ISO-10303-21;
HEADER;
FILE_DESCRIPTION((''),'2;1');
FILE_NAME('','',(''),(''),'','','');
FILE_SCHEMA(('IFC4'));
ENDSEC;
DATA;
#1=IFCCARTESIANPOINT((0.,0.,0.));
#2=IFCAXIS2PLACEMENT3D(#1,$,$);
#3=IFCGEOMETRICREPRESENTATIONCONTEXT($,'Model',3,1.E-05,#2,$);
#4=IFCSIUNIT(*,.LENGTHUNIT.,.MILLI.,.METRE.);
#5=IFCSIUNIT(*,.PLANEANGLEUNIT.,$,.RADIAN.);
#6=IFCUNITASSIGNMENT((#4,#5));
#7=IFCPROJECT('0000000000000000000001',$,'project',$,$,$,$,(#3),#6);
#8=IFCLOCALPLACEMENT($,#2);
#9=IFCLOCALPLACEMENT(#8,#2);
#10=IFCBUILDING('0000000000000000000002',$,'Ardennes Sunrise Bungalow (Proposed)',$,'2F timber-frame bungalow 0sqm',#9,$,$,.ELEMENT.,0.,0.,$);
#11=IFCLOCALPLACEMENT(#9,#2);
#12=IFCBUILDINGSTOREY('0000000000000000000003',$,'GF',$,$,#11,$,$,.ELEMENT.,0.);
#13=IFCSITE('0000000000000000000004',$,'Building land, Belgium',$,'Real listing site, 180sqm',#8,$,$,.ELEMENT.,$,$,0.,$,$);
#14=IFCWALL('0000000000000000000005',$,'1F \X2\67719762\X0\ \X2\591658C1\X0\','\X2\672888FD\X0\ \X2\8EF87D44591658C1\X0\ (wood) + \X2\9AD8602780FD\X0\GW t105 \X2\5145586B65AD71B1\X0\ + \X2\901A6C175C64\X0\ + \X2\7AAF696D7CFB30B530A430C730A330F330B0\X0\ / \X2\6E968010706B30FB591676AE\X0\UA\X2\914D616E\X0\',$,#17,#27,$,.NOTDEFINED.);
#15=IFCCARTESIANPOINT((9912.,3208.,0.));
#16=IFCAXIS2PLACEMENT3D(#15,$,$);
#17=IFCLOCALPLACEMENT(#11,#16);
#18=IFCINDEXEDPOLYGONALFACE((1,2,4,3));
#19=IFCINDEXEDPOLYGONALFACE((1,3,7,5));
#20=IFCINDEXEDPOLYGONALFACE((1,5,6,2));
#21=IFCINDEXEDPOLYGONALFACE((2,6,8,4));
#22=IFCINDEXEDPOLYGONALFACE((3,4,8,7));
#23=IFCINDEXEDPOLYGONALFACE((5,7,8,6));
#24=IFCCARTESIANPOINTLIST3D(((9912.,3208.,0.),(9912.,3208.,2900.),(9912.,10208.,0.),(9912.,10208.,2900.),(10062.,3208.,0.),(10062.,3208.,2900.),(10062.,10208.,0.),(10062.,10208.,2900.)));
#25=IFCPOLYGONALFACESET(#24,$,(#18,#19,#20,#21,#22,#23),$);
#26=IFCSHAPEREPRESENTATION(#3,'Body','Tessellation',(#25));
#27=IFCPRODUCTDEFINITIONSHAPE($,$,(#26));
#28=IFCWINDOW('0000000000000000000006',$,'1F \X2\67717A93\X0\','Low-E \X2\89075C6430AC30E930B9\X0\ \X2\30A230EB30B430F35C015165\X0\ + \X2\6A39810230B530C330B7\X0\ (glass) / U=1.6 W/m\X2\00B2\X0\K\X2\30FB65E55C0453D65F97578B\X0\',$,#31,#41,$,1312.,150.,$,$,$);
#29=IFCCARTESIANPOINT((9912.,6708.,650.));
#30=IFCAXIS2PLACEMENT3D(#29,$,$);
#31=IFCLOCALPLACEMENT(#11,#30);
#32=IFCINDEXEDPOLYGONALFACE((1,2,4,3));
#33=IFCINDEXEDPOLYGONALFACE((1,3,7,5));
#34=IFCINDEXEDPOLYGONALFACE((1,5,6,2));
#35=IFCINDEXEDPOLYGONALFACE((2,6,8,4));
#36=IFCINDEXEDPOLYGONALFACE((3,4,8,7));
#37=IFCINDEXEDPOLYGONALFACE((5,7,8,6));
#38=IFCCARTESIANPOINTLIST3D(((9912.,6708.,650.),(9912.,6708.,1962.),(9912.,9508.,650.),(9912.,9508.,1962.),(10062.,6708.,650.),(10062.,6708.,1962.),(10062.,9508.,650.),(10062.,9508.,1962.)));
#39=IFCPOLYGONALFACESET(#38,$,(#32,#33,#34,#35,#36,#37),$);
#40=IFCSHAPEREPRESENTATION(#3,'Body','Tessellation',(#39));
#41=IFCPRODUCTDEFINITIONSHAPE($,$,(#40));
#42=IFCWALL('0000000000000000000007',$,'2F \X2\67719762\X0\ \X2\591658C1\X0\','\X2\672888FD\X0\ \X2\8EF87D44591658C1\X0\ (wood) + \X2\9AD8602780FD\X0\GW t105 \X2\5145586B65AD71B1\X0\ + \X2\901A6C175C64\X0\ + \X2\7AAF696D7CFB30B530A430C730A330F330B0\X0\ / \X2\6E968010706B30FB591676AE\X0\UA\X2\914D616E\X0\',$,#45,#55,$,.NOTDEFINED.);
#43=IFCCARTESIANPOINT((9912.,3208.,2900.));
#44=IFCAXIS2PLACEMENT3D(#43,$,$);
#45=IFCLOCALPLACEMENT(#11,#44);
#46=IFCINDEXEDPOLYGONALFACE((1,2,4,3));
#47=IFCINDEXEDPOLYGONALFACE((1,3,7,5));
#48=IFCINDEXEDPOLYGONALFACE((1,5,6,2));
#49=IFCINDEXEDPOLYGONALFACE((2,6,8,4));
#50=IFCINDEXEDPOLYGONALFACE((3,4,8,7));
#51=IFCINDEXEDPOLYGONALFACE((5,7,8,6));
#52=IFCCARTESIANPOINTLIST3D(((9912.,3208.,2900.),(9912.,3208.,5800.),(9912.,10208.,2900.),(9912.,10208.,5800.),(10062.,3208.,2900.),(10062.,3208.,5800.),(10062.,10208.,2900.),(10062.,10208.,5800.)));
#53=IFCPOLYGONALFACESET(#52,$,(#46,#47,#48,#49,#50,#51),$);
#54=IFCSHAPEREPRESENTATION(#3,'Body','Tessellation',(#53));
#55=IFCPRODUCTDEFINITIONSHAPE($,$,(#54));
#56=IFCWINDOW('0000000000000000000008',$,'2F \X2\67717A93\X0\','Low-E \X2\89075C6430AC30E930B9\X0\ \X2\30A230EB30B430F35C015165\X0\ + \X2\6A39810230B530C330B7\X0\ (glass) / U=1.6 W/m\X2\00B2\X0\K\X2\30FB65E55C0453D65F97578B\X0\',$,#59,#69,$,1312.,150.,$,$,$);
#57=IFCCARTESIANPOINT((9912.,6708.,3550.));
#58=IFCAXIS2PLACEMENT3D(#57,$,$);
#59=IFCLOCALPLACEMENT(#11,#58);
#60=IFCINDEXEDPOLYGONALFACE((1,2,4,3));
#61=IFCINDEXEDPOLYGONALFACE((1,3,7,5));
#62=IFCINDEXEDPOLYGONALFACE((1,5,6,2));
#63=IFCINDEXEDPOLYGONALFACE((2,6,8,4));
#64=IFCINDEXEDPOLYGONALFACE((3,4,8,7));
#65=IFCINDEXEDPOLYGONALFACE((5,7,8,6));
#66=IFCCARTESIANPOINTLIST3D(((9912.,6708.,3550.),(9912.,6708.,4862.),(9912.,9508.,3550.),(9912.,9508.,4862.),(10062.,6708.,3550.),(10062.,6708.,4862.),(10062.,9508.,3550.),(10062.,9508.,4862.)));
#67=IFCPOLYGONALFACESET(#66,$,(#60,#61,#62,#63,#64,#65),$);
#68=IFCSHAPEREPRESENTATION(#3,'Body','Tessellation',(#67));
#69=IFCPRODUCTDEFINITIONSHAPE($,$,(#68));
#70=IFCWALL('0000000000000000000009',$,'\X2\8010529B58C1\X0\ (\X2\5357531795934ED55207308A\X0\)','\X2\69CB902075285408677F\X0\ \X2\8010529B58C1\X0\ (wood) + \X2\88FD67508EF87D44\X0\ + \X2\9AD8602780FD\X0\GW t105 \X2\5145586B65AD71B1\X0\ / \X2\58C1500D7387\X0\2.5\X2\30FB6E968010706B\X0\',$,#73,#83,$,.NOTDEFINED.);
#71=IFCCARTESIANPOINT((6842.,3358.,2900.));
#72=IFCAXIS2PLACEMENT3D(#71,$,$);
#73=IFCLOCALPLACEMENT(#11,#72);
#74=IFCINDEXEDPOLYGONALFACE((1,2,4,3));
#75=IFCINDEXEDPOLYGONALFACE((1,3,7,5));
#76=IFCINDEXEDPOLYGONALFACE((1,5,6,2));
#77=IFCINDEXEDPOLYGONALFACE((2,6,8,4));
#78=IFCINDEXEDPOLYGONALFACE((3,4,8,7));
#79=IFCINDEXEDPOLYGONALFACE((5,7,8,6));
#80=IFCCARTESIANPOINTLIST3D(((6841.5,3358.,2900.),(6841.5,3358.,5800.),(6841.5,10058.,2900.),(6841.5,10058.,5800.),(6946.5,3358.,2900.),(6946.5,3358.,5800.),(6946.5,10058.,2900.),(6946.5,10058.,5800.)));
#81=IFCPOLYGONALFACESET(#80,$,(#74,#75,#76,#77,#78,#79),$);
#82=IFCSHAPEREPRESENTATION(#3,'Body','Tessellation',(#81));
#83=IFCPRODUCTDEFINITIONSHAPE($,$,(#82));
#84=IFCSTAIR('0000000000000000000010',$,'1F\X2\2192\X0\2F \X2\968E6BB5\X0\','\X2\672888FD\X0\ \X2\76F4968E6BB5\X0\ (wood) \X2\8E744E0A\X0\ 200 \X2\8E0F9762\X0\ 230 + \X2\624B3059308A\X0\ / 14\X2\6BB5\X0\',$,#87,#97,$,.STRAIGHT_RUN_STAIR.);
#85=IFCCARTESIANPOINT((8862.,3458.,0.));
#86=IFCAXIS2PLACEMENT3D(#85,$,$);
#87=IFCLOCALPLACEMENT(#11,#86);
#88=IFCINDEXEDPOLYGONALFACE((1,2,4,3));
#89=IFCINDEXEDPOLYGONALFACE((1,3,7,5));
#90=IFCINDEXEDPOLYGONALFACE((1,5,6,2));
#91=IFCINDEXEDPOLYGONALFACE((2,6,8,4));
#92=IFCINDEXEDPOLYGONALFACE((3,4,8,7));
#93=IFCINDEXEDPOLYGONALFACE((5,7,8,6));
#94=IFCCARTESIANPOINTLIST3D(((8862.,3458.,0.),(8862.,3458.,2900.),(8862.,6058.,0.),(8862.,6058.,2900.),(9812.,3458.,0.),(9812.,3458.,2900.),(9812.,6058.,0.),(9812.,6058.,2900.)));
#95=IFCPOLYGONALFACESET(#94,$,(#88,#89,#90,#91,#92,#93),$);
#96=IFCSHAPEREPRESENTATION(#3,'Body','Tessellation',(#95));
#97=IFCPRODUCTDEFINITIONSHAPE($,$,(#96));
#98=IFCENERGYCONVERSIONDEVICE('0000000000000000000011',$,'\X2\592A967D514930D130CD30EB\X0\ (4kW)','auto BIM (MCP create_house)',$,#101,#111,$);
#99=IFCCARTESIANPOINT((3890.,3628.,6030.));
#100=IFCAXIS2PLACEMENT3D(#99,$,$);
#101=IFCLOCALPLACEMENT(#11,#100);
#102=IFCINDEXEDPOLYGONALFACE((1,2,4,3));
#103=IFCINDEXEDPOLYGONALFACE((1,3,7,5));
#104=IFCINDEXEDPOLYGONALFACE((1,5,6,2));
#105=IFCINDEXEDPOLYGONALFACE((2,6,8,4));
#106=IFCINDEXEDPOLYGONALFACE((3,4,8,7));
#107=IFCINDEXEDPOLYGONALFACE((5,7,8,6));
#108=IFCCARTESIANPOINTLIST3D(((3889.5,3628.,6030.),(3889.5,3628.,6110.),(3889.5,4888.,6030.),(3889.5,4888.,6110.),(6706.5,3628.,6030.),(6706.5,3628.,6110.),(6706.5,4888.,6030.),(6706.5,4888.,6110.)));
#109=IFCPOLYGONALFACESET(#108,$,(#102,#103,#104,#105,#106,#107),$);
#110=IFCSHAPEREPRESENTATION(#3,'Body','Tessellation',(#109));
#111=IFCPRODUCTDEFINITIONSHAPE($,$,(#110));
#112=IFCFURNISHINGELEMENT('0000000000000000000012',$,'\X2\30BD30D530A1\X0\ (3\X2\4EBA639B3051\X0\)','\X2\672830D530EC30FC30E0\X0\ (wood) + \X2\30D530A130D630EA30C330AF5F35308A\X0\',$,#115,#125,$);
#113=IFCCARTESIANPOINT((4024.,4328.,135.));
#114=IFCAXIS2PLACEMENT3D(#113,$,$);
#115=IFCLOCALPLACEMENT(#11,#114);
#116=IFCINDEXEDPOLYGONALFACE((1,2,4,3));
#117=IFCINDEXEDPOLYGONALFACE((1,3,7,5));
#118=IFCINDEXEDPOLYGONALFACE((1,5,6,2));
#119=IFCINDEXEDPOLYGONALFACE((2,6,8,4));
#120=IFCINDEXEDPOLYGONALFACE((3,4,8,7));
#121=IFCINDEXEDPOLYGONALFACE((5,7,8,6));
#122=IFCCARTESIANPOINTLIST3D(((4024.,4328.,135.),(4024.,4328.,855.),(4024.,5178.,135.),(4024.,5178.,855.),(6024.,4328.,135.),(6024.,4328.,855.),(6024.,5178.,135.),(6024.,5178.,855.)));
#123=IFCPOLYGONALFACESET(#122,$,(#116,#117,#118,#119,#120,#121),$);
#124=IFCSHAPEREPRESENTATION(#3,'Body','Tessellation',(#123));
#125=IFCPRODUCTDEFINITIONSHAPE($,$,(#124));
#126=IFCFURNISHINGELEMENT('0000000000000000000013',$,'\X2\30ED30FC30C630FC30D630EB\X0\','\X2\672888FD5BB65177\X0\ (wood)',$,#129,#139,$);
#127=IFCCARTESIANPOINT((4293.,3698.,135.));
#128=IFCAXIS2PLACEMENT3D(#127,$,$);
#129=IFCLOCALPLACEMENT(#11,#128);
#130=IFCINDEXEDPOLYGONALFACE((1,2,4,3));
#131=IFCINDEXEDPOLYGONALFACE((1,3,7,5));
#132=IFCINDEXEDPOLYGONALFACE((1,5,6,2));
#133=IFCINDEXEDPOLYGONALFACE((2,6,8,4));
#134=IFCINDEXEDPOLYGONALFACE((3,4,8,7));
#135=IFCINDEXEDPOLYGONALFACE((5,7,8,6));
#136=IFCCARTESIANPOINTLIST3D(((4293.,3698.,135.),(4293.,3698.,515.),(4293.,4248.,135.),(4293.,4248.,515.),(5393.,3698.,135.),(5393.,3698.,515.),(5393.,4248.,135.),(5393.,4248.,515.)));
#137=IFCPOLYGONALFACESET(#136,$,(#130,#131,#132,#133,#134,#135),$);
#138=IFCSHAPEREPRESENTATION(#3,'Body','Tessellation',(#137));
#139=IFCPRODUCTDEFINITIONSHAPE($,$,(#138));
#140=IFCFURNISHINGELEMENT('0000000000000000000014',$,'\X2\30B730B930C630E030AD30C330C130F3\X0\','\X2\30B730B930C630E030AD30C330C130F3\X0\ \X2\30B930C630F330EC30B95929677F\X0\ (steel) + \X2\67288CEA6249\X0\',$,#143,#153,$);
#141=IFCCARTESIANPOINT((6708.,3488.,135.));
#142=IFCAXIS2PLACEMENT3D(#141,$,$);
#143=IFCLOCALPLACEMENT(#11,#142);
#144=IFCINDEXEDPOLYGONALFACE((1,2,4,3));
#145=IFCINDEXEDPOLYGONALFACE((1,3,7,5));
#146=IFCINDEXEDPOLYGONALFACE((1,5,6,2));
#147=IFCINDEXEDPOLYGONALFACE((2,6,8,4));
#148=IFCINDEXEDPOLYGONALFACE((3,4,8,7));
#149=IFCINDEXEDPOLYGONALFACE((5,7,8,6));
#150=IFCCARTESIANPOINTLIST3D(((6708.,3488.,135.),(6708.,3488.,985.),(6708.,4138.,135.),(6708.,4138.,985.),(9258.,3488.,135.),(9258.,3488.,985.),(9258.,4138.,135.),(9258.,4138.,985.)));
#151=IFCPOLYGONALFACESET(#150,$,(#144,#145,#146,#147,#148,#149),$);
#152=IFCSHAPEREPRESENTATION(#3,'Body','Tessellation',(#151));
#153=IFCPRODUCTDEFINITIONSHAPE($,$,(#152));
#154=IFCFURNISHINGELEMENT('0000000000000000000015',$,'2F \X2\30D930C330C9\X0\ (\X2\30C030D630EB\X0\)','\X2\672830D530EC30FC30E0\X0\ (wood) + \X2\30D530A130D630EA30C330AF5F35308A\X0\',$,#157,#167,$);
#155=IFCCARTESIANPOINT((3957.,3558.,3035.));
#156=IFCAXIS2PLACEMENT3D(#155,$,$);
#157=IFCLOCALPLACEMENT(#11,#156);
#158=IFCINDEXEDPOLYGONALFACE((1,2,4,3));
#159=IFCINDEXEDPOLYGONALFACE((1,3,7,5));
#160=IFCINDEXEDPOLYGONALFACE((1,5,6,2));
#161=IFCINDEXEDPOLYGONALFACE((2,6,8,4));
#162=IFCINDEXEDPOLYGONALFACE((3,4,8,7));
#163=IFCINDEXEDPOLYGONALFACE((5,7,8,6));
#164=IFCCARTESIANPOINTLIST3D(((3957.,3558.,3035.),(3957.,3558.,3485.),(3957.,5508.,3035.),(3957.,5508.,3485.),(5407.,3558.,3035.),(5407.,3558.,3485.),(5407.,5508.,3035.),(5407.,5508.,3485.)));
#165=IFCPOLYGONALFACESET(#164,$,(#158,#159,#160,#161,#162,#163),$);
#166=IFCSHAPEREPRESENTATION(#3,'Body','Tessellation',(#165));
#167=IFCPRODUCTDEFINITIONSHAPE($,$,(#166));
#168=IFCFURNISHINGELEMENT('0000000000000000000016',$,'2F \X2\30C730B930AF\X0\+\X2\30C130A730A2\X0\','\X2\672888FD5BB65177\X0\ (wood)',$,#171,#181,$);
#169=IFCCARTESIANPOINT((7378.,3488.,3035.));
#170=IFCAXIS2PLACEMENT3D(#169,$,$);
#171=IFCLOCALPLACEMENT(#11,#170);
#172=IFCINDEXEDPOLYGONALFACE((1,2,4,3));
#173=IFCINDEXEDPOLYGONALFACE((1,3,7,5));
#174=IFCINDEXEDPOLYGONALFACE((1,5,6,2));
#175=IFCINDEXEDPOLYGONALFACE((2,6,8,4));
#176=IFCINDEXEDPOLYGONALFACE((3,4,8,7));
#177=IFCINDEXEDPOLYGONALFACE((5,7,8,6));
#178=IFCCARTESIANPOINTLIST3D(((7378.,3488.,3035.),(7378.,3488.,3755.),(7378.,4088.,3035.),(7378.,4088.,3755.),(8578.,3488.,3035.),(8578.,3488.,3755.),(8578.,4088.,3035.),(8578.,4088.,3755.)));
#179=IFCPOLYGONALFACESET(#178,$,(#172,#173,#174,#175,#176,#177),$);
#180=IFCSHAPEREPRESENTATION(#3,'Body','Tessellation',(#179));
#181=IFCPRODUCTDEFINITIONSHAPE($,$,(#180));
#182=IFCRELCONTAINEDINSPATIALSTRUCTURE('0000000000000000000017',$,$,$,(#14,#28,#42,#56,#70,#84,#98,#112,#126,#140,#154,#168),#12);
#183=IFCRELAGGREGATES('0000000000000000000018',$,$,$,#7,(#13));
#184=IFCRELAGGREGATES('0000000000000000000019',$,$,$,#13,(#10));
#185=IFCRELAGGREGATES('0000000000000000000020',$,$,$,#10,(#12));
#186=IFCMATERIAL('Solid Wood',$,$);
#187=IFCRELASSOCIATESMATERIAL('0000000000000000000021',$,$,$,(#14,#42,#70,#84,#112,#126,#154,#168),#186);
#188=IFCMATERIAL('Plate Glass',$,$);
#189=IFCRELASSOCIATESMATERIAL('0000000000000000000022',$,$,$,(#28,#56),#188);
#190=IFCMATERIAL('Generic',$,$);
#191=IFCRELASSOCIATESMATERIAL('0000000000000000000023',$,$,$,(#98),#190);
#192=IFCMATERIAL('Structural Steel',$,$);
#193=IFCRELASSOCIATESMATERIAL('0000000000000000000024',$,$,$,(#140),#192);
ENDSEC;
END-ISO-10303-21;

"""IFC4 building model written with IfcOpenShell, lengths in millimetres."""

from ifc_helpers import new_model, si_unit, frame, frame_2d, origin, place, context, project, spatial, rectangle, extrude, material, element, fill, save


model = new_model("IFC4")

# Units and contexts
model_context = context("Model", 3, precision=1e-05, world=origin())
ifc_project = project(units=[si_unit("LENGTHUNIT", "METRE", prefix="MILLI"), si_unit("PLANEANGLEUNIT", "RADIAN")], contexts=[model_context])

# Site, building, storey
site_placement = place(None, origin())
site = spatial("IfcSite", under=ifc_project, at=site_placement, Name="Building land, Belgium", ObjectType="Real listing site, 180sqm", CompositionType="ELEMENT", RefElevation=0.0)
building_placement = place(site_placement, origin())
building = spatial("IfcBuilding", under=site, at=building_placement, Name="Ardennes Sunrise Bungalow (Proposed)", ObjectType="2F timber-frame bungalow 0sqm", CompositionType="ELEMENT", ElevationOfRefHeight=0.0, ElevationOfTerrain=0.0)
storey_placement = place(building_placement, origin())
storey = spatial("IfcBuildingStorey", under=building, at=storey_placement, Name="GF", CompositionType="ELEMENT", Elevation=0.0)

# Wall, opening, window
ifc_material_1 = material(Name="Solid Wood")
wall_1_placement = place(storey_placement, frame((9912.0, 3208.0, 0.0)))
wall_1 = element("IfcWall", 1, at=wall_1_placement, inside=storey, material=ifc_material_1, Name="1F 東面 外壁", Description="木製 軸組外壁 (wood) + 高性能GW t105 充填断熱 + 通気層 + 窯業系サイディング / 準耐火・外皮UA配慮", PredefinedType="NOTDEFINED", context=model_context, shape_type="SweptSolid", body=[
    extrude(rectangle(XDim=150.0, YDim=7000.0, at=frame_2d((75.0, 3500.0))), frame((9912.0, 3208.0, 0.0)), (0.0, 0.0, 1.0), 2900.0),
])
opening_1_placement = place(storey_placement, frame((9912.0, 6708.0, 650.0)))
opening_1 = element("IfcOpeningElement", 2, at=opening_1_placement, cuts=wall_1, PredefinedType="NOTDEFINED", context=model_context, shape_type="SweptSolid", body=[
    extrude(rectangle(XDim=150.0, YDim=2800.0, at=frame_2d((75.0, 1400.0))), frame((9912.0, 6708.0, 650.0)), (0.0, 0.0, 1.0), 1312.0),
])
ifc_material_2 = material(Name="Plate Glass")
window_1_placement = place(storey_placement, frame((9912.0, 6708.0, 650.0)))
window_1 = element("IfcWindow", 3, at=window_1_placement, inside=storey, material=ifc_material_2, Name="1F 東窓", Description="Low-E 複層ガラス アルゴン封入 + 樹脂サッシ (glass) / U=1.6 W/m²K・日射取得型", OverallHeight=1312.0, OverallWidth=150.0, context=model_context, shape_type="SweptSolid", body=[
    extrude(rectangle(XDim=150.0, YDim=2800.0, at=frame_2d((75.0, 1400.0))), frame((9912.0, 6708.0, 650.0)), (0.0, 0.0, 1.0), 1312.0),
])
fill(opening_1, window_1)

# Wall, opening, window
wall_2_placement = place(storey_placement, frame((9912.0, 3208.0, 2900.0)))
wall_2 = element("IfcWall", 4, at=wall_2_placement, inside=storey, material=ifc_material_1, Name="2F 東面 外壁", Description="木製 軸組外壁 (wood) + 高性能GW t105 充填断熱 + 通気層 + 窯業系サイディング / 準耐火・外皮UA配慮", PredefinedType="NOTDEFINED", context=model_context, shape_type="SweptSolid", body=[
    extrude(rectangle(XDim=150.0, YDim=7000.0, at=frame_2d((75.0, 3500.0))), frame((9912.0, 3208.0, 2900.0)), (0.0, 0.0, 1.0), 2900.0),
])
opening_2_placement = place(storey_placement, frame((9912.0, 6708.0, 3550.0)))
opening_2 = element("IfcOpeningElement", 5, at=opening_2_placement, cuts=wall_2, PredefinedType="NOTDEFINED", context=model_context, shape_type="SweptSolid", body=[
    extrude(rectangle(XDim=150.0, YDim=2800.0, at=frame_2d((75.0, 1400.0))), frame((9912.0, 6708.0, 3550.0)), (0.0, 0.0, 1.0), 1312.0),
])
window_2_placement = place(storey_placement, frame((9912.0, 6708.0, 3550.0)))
window_2 = element("IfcWindow", 6, at=window_2_placement, inside=storey, material=ifc_material_2, Name="2F 東窓", Description="Low-E 複層ガラス アルゴン封入 + 樹脂サッシ (glass) / U=1.6 W/m²K・日射取得型", OverallHeight=1312.0, OverallWidth=150.0, context=model_context, shape_type="SweptSolid", body=[
    extrude(rectangle(XDim=150.0, YDim=2800.0, at=frame_2d((75.0, 1400.0))), frame((9912.0, 6708.0, 3550.0)), (0.0, 0.0, 1.0), 1312.0),
])
fill(opening_2, window_2)

# Wall
wall_3_placement = place(storey_placement, frame((6842.0, 3358.0, 2900.0)))
element("IfcWall", 7, at=wall_3_placement, inside=storey, material=ifc_material_1, Name="耐力壁 (南北間仕切り)", Description="構造用合板 耐力壁 (wood) + 製材軸組 + 高性能GW t105 充填断熱 / 壁倍率2.5・準耐火", PredefinedType="NOTDEFINED", context=model_context, shape_type="SweptSolid", body=[
    extrude(rectangle(XDim=105.0, YDim=6700.0, at=frame_2d((52.0, 3350.0))), frame((6842.0, 3358.0, 2900.0)), (0.0, 0.0, 1.0), 2900.0),
])

# Stair
stair_placement = place(storey_placement, frame((8862.0, 3458.0, 0.0)))
element("IfcStair", 8, at=stair_placement, inside=storey, material=ifc_material_1, Name="1F→2F 階段", Description="木製 直階段 (wood) 蹴上 200 踏面 230 + 手すり / 14段", PredefinedType="STRAIGHT_RUN_STAIR", context=model_context, shape_type="SweptSolid", body=[
    extrude(rectangle(XDim=950.0, YDim=2600.0, at=frame_2d((475.0, 1300.0))), frame((8862.0, 3458.0, 0.0)), (0.0, 0.0, 1.0), 2900.0),
])

# Energy conversion device
ifc_material_3 = material(Name="Generic")
energy_conversion_device_placement = place(storey_placement, frame((3890.0, 3628.0, 6030.0)))
element("IfcEnergyConversionDevice", 9, at=energy_conversion_device_placement, inside=storey, material=ifc_material_3, Name="太陽光パネル (4kW)", Description="auto BIM (MCP create_house)", context=model_context, shape_type="SweptSolid", body=[
    extrude(rectangle(XDim=2817.0, YDim=1260.0, at=frame_2d((1408.0, 630.0))), frame((3890.0, 3628.0, 6030.0)), (0.0, 0.0, 1.0), 80.0),
])

# Furnishing elements
furnishing_1_placement = place(storey_placement, frame((4024.0, 4328.0, 135.0)))
element("IfcFurnishingElement", 10, at=furnishing_1_placement, inside=storey, material=ifc_material_1, Name="ソファ (3人掛け)", Description="木フレーム (wood) + ファブリック張り", context=model_context, shape_type="SweptSolid", body=[
    extrude(rectangle(XDim=2000.0, YDim=850.0, at=frame_2d((1000.0, 425.0))), frame((4024.0, 4328.0, 135.0)), (0.0, 0.0, 1.0), 720.0),
])
furnishing_2_placement = place(storey_placement, frame((4293.0, 3698.0, 135.0)))
element("IfcFurnishingElement", 11, at=furnishing_2_placement, inside=storey, material=ifc_material_1, Name="ローテーブル", Description="木製家具 (wood)", context=model_context, shape_type="SweptSolid", body=[
    extrude(rectangle(XDim=1100.0, YDim=550.0, at=frame_2d((550.0, 275.0))), frame((4293.0, 3698.0, 135.0)), (0.0, 0.0, 1.0), 380.0),
])
ifc_material_4 = material(Name="Structural Steel")
furnishing_3_placement = place(storey_placement, frame((6708.0, 3488.0, 135.0)))
element("IfcFurnishingElement", 12, at=furnishing_3_placement, inside=storey, material=ifc_material_4, Name="システムキッチン", Description="システムキッチン ステンレス天板 (steel) + 木質扉", context=model_context, shape_type="SweptSolid", body=[
    extrude(rectangle(XDim=2550.0, YDim=650.0, at=frame_2d((1275.0, 325.0))), frame((6708.0, 3488.0, 135.0)), (0.0, 0.0, 1.0), 850.0),
])
furnishing_4_placement = place(storey_placement, frame((3957.0, 3558.0, 3035.0)))
element("IfcFurnishingElement", 13, at=furnishing_4_placement, inside=storey, material=ifc_material_1, Name="2F ベッド (ダブル)", Description="木フレーム (wood) + ファブリック張り", context=model_context, shape_type="SweptSolid", body=[
    extrude(rectangle(XDim=1450.0, YDim=1950.0, at=frame_2d((725.0, 975.0))), frame((3957.0, 3558.0, 3035.0)), (0.0, 0.0, 1.0), 450.0),
])
furnishing_5_placement = place(storey_placement, frame((7378.0, 3488.0, 3035.0)))
element("IfcFurnishingElement", 14, at=furnishing_5_placement, inside=storey, material=ifc_material_1, Name="2F デスク+チェア", Description="木製家具 (wood)", context=model_context, shape_type="SweptSolid", body=[
    extrude(rectangle(XDim=1200.0, YDim=600.0, at=frame_2d((600.0, 300.0))), frame((7378.0, 3488.0, 3035.0)), (0.0, 0.0, 1.0), 720.0),
])

save(model, "model.ifc")
